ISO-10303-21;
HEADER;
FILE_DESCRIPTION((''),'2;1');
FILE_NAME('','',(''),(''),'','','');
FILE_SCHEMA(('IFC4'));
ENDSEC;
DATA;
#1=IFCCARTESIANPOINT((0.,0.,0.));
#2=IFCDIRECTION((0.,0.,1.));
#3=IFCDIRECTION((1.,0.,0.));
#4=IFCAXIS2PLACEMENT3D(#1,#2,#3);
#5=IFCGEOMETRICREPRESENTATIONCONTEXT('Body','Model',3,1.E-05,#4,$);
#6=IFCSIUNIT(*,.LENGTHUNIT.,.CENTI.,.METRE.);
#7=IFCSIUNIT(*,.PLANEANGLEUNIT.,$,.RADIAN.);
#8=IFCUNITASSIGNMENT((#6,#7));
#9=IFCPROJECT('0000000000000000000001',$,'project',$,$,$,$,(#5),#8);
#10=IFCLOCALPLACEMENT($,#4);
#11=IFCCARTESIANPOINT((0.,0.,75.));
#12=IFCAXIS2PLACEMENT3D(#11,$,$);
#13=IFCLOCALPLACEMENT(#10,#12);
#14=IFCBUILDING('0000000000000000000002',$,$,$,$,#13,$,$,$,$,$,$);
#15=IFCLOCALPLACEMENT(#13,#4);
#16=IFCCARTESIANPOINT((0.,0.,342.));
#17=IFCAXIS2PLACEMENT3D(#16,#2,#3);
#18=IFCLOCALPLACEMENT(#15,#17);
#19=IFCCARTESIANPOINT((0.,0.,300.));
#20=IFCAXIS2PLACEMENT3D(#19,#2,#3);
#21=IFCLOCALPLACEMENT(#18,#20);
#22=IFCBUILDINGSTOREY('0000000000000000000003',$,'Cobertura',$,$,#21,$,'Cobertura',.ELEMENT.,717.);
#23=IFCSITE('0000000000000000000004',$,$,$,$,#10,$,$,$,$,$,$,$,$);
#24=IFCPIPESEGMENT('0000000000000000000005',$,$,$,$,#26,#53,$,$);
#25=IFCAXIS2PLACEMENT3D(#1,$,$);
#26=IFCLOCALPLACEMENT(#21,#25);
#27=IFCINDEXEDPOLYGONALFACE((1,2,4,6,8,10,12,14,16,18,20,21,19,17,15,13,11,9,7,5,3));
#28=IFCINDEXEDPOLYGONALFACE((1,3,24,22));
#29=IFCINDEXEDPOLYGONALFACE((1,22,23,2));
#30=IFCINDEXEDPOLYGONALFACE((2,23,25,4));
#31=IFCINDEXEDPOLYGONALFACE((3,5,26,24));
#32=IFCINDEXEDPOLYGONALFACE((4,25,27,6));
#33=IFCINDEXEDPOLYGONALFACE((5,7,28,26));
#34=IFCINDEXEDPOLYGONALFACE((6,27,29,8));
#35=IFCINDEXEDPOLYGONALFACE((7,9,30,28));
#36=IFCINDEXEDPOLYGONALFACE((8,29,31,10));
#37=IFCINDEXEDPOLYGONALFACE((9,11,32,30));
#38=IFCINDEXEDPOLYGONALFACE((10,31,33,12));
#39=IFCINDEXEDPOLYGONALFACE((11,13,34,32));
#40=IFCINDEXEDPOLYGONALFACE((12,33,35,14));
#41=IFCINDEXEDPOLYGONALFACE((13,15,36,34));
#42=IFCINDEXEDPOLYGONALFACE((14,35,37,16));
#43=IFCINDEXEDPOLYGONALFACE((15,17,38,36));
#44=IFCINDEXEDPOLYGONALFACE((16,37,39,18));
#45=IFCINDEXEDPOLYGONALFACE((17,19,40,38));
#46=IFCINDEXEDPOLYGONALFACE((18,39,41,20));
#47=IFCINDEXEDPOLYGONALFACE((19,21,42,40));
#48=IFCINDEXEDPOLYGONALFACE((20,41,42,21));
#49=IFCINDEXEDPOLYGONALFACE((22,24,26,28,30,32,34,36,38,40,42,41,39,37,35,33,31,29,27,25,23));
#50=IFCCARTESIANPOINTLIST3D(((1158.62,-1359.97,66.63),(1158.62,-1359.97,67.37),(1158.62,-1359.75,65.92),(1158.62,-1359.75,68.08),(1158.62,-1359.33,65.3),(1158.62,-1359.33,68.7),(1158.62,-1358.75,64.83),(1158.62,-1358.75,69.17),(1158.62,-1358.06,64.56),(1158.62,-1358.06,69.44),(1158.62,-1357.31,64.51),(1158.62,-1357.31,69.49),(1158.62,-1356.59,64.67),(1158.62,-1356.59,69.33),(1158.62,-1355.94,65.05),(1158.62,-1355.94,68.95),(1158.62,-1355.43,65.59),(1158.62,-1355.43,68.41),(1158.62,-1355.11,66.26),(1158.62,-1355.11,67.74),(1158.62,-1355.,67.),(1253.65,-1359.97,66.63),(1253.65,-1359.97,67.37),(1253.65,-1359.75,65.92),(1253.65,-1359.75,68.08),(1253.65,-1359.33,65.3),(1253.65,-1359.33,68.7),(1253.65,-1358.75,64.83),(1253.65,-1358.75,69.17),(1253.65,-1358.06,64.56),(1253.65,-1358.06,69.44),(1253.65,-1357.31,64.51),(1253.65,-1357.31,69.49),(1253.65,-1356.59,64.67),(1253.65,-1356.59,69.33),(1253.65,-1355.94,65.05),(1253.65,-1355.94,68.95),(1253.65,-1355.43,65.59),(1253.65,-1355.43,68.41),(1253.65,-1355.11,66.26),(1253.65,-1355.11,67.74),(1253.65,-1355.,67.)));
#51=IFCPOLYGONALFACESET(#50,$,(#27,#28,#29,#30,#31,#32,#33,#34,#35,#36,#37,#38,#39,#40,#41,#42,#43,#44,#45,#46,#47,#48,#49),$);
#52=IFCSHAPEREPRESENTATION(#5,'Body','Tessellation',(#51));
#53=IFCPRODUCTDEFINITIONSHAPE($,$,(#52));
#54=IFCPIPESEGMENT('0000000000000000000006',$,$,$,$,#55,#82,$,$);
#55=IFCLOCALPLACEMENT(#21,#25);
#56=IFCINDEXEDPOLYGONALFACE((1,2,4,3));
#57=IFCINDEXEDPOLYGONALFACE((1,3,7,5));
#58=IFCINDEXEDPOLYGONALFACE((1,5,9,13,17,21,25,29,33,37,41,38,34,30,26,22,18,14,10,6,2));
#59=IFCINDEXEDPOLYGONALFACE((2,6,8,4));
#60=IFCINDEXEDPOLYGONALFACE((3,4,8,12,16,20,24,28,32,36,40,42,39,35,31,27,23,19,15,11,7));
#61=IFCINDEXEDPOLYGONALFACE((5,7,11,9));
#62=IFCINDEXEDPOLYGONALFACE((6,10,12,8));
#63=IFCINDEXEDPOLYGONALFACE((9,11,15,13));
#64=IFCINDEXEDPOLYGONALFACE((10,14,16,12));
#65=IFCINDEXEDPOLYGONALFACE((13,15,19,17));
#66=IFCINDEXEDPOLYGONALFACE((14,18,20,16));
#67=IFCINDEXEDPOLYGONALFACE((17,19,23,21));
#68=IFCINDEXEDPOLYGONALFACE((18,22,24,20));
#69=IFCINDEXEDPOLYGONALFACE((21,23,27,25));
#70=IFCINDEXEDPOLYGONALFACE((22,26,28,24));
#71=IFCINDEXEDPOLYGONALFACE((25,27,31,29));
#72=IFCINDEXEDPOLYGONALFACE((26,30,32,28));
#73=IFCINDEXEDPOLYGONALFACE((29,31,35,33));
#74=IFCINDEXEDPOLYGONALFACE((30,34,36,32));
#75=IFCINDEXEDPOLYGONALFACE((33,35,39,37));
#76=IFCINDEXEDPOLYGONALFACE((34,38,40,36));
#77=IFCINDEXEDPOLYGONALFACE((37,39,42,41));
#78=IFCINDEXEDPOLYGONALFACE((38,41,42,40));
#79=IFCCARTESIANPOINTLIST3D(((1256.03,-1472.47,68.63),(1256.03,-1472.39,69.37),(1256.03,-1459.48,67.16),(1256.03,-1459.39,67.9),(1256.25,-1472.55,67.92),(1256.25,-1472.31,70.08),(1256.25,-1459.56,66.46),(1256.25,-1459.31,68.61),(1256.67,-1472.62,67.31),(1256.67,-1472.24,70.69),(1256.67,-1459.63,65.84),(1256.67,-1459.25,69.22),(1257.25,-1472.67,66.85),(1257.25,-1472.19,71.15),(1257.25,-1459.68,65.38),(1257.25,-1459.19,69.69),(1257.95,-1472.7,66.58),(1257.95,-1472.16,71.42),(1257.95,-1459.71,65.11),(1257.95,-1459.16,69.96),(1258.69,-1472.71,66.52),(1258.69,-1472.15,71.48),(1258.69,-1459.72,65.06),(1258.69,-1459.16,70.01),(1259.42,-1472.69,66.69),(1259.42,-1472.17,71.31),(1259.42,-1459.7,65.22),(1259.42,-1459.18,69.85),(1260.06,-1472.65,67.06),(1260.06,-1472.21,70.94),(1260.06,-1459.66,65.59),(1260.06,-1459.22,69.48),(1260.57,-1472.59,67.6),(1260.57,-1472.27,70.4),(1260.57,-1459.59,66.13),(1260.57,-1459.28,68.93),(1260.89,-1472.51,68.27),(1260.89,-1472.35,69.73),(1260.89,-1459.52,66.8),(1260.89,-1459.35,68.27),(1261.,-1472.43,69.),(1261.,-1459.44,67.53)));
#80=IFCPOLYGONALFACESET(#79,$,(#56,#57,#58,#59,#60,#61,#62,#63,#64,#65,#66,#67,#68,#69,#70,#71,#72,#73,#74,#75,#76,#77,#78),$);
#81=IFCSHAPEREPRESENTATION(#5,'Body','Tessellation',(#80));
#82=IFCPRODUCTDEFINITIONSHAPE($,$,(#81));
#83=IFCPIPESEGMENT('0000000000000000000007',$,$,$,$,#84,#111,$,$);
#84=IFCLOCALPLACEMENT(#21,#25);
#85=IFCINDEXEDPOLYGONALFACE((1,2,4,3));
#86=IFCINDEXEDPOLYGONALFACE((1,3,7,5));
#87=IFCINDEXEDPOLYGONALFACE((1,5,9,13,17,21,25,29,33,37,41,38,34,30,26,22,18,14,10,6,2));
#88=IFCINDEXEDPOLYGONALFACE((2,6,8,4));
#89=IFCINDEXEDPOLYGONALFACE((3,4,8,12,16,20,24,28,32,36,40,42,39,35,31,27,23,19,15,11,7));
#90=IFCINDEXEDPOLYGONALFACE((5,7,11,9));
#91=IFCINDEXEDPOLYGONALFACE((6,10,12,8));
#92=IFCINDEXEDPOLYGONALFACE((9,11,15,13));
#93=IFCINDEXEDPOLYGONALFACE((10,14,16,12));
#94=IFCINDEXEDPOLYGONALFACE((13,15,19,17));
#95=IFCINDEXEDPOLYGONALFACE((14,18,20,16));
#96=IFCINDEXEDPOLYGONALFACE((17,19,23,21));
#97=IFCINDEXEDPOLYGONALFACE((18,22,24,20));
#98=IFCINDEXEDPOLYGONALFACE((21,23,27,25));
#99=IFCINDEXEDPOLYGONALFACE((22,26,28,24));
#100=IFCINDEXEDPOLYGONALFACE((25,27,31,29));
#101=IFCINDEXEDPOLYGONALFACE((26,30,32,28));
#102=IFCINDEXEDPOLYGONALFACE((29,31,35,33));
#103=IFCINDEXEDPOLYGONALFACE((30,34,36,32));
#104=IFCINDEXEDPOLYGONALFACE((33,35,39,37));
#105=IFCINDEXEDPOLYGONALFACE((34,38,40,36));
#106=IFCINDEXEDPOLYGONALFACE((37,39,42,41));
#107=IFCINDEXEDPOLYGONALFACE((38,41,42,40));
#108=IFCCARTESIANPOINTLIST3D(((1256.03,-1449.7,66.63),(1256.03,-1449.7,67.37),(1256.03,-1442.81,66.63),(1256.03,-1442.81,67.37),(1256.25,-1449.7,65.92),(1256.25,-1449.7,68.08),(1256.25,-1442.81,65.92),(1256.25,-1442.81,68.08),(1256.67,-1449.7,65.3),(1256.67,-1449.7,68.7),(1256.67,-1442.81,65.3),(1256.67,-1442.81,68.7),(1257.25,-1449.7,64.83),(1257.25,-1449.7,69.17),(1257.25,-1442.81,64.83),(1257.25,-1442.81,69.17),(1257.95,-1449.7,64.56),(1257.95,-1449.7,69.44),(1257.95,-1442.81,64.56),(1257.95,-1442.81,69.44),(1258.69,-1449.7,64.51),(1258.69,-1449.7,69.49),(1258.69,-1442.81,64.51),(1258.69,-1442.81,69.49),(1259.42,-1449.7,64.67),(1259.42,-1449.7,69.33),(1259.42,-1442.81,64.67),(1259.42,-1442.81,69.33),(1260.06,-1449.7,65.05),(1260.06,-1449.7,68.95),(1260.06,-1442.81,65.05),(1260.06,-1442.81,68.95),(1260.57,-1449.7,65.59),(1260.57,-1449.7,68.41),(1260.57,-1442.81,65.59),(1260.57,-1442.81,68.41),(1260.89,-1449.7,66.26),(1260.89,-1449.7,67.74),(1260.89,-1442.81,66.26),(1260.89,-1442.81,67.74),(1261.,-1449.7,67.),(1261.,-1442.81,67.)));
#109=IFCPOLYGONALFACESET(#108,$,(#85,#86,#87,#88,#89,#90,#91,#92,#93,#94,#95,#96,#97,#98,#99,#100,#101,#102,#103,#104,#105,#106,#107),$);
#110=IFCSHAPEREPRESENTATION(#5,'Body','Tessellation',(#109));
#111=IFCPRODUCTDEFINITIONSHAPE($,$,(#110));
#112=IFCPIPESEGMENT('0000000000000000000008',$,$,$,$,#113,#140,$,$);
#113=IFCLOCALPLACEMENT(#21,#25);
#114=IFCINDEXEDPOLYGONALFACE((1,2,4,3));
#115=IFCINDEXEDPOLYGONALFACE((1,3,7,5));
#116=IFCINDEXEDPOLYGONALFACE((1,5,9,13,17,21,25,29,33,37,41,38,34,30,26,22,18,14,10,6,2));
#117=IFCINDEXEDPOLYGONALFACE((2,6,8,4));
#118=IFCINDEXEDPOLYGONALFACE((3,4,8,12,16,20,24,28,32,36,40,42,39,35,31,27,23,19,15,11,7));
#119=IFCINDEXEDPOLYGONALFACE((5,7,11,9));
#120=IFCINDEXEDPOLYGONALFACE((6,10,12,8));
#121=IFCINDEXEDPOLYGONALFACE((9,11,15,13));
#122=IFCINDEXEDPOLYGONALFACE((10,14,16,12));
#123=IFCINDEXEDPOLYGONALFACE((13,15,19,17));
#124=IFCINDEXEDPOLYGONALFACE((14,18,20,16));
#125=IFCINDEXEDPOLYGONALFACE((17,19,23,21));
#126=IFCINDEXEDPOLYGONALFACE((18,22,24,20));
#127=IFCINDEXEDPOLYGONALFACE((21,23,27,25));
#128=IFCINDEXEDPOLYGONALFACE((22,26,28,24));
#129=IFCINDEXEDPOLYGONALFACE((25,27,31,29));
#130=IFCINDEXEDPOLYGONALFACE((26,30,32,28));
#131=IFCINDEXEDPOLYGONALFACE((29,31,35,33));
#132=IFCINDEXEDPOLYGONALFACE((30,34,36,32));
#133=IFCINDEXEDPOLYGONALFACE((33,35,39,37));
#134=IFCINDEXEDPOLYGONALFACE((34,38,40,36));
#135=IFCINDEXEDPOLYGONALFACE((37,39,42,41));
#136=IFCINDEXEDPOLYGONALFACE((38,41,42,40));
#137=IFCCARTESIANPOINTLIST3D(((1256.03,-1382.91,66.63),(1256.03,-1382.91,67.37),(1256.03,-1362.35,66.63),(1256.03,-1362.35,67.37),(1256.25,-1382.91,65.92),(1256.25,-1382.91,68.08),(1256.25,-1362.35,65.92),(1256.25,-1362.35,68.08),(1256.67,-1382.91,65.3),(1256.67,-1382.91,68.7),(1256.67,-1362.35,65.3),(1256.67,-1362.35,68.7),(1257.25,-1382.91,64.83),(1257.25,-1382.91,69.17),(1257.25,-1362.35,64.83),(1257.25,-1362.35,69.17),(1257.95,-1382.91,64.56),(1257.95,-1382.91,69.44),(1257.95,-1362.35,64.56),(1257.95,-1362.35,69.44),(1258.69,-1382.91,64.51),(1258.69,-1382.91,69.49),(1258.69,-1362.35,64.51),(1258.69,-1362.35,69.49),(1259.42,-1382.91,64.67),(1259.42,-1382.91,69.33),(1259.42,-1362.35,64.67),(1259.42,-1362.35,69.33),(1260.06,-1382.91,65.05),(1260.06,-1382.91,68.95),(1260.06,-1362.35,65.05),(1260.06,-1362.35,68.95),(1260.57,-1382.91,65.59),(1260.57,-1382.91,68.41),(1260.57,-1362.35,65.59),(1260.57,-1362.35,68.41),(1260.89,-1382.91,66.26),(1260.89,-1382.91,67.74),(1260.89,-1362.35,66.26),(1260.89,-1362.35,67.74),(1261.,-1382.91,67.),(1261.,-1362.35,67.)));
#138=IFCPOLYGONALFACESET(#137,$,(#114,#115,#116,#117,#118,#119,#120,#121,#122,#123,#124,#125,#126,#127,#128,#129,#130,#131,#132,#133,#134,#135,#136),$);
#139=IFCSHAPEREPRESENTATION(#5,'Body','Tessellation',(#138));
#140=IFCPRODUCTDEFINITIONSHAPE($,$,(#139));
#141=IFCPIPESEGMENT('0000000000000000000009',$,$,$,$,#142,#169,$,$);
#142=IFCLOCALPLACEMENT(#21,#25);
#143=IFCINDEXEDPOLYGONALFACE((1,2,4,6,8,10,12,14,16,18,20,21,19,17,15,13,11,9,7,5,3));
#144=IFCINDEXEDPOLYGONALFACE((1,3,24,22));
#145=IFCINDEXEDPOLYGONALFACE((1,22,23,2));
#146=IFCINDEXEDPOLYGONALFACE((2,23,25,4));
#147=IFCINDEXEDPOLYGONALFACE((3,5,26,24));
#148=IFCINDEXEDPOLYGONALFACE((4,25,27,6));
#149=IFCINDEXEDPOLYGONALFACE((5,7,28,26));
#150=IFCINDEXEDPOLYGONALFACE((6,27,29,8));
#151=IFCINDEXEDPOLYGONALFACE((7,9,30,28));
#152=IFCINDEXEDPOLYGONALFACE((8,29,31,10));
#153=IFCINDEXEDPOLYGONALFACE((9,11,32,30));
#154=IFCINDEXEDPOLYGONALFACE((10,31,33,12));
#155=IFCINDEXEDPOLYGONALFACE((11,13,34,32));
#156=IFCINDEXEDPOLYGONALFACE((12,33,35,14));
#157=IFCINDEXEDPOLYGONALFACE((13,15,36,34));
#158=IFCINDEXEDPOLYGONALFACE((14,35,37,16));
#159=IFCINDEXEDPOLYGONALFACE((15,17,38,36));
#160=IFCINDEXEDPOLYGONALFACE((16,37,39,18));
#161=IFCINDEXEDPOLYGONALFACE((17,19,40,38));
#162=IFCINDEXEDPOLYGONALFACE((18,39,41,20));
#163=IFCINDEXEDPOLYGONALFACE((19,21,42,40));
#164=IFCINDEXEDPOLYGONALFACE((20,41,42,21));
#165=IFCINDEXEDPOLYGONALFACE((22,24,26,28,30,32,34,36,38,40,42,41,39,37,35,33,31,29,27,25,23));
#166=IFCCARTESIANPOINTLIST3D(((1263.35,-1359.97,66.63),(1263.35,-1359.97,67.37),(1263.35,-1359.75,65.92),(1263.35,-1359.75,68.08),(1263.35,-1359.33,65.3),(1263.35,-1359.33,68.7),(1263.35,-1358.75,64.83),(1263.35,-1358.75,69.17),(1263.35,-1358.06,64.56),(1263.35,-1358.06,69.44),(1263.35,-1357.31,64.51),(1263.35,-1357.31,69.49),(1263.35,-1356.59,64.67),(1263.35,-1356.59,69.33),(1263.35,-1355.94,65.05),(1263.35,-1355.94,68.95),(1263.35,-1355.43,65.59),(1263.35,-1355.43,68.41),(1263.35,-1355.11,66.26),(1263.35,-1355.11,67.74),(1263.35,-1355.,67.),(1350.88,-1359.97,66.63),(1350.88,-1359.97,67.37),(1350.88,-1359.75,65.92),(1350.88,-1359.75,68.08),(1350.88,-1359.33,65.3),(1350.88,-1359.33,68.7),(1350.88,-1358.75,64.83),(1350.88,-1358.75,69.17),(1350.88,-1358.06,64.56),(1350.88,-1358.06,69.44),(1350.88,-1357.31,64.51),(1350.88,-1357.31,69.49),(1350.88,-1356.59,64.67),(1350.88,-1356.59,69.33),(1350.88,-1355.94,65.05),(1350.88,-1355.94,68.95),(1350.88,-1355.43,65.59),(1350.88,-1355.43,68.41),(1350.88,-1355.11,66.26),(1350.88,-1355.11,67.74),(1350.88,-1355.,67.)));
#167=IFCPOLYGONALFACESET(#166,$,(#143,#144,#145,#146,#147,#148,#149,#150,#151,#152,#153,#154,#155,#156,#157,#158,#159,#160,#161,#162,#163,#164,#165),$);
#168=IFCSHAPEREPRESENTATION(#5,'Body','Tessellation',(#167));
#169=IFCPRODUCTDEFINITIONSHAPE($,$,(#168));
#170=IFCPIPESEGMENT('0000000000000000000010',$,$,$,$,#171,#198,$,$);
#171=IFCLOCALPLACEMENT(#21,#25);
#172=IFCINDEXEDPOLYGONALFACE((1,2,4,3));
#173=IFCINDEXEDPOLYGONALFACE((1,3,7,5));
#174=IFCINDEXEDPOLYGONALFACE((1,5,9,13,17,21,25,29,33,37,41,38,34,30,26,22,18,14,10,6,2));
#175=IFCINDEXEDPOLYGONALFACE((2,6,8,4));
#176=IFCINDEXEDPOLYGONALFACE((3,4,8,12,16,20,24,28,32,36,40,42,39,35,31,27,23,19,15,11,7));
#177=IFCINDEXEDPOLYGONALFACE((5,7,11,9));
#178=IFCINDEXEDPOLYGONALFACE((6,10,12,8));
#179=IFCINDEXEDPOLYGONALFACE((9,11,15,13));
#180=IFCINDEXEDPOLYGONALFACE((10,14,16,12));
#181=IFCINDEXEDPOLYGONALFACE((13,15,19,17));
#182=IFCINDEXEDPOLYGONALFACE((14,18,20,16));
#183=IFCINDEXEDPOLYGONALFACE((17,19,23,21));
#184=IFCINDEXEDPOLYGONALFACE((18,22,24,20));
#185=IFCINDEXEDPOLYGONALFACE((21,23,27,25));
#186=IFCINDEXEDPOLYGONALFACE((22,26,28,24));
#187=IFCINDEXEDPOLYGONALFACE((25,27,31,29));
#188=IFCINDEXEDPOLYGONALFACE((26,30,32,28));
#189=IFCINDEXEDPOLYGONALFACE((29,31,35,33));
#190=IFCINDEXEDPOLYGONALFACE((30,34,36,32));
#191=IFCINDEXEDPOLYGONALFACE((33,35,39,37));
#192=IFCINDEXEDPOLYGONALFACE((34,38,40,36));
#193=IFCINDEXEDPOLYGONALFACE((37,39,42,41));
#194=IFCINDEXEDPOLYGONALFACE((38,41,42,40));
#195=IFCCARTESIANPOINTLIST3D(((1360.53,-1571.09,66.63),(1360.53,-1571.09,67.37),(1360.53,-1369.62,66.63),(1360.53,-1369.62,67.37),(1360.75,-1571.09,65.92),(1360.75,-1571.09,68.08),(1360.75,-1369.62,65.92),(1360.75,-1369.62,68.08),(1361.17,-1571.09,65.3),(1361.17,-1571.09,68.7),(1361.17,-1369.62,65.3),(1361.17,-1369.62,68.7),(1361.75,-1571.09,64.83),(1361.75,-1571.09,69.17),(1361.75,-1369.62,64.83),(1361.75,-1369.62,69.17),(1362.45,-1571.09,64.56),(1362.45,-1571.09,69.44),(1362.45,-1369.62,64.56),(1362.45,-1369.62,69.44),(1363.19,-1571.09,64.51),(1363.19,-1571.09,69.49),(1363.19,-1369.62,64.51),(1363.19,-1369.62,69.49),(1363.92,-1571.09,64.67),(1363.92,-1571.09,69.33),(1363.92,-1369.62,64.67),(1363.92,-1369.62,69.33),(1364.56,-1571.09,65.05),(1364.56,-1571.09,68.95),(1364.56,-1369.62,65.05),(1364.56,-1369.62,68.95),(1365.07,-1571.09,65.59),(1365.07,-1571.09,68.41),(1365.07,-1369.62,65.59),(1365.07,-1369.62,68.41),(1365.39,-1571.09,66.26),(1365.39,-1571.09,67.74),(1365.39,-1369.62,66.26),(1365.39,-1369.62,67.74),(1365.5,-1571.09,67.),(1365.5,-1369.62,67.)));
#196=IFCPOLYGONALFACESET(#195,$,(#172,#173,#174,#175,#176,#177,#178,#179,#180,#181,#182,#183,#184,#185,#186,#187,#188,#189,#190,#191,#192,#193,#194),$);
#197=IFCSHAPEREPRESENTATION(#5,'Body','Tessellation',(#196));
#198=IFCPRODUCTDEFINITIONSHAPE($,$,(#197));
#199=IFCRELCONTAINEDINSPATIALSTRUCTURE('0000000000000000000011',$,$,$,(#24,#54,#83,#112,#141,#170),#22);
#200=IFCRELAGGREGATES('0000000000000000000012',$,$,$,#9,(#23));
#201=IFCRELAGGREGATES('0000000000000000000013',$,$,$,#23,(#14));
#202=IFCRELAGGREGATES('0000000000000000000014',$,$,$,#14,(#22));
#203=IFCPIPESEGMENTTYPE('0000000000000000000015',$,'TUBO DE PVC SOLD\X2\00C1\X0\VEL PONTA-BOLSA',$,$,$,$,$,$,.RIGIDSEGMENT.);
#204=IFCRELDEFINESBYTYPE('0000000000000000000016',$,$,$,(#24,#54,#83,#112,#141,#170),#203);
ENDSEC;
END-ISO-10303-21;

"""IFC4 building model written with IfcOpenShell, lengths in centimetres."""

from ifc_helpers import new_model, si_unit, frame, origin_with_axes, origin_2d_with_axis, place, context, project, spatial, circle, extrude, type_object, element, save


model = new_model("IFC4")

# Units and contexts
model_context = context("Model", 3, precision=1e-05, world=origin_with_axes(), identifier="Body")
ifc_project = project(units=[si_unit("LENGTHUNIT", "METRE", prefix="CENTI"), si_unit("PLANEANGLEUNIT", "RADIAN")], contexts=[model_context])

# Site, building, storey
site_placement = place(None, origin_with_axes())
site = spatial("IfcSite", under=ifc_project, at=site_placement)
building_placement = place(site_placement, frame((0.0, 0.0, 75.0)))
building = spatial("IfcBuilding", under=site, at=building_placement)
placement_1 = place(building_placement, origin_with_axes())
placement_2 = place(placement_1, frame((0.0, 0.0, 342.0), z_axis=(0.0, 0.0, 1.0), x_axis=(1.0, 0.0, 0.0)))
storey_placement = place(placement_2, frame((0.0, 0.0, 300.0), z_axis=(0.0, 0.0, 1.0), x_axis=(1.0, 0.0, 0.0)))
storey = spatial("IfcBuildingStorey", under=building, at=storey_placement, Name="Cobertura", LongName="Cobertura", CompositionType="ELEMENT", Elevation=717.0)

# Pipe segments
pipe_segment_type_1 = type_object("IfcPipeSegmentType", Name="TUBO DE PVC SOLDÁVEL PONTA-BOLSA", PredefinedType="RIGIDSEGMENT")
pipe_segment_1_placement = place(storey_placement, frame((1206.14, -1357.5, 69.5), z_axis=(0.0, 0.0, 1.0), x_axis=(1.0, 0.0, 0.0)))
element("IfcPipeSegment", 1, at=pipe_segment_1_placement, inside=storey, type_object=pipe_segment_type_1, context=model_context, shape_type="SolidModel", body=[
    extrude(circle(Radius=2.5, at=origin_2d_with_axis()), frame((47.52, 0.0, -2.5), z_axis=(-1.0, 0.0, 0.0), x_axis=(0.0, 1.0, 0.0)), (0.0, 0.0, 1.0), 95.03),
])
pipe_segment_2_placement = place(storey_placement, frame((1258.5, -1465.93, 71.48), z_axis=(0.0, 0.0, 1.0), x_axis=(1.0, 0.0, 0.0)))
element("IfcPipeSegment", 2, at=pipe_segment_2_placement, inside=storey, type_object=pipe_segment_type_1, context=model_context, shape_type="SolidModel", body=[
    extrude(circle(Radius=2.5, at=origin_2d_with_axis()), frame((0.0, -6.5, -2.48), z_axis=(0.0, 0.993693, -0.112136), x_axis=(1.0, 0.0, 0.0)), (0.0, 0.0, 1.0), 13.08),
])
pipe_segment_3_placement = place(storey_placement, frame((1258.5, -1446.26, 69.5), z_axis=(0.0, 0.0, 1.0), x_axis=(1.0, 0.0, 0.0)))
element("IfcPipeSegment", 3, at=pipe_segment_3_placement, inside=storey, type_object=pipe_segment_type_1, context=model_context, shape_type="SolidModel", body=[
    extrude(circle(Radius=2.5, at=origin_2d_with_axis()), frame((0.0, -3.45, -2.5), z_axis=(0.0, 1.0, 0.0), x_axis=(1.0, 0.0, 0.0)), (0.0, 0.0, 1.0), 6.9),
])
pipe_segment_4_placement = place(storey_placement, frame((1258.5, -1372.63, 69.5), z_axis=(0.0, 0.0, 1.0), x_axis=(1.0, 0.0, 0.0)))
element("IfcPipeSegment", 4, at=pipe_segment_4_placement, inside=storey, type_object=pipe_segment_type_1, context=model_context, shape_type="SolidModel", body=[
    extrude(circle(Radius=2.5, at=origin_2d_with_axis()), frame((0.0, -10.28, -2.5), z_axis=(0.0, 1.0, 0.0), x_axis=(1.0, 0.0, 0.0)), (0.0, 0.0, 1.0), 20.56),
])
pipe_segment_5_placement = place(storey_placement, frame((1307.12, -1357.5, 69.5), z_axis=(0.0, 0.0, 1.0), x_axis=(1.0, 0.0, 0.0)))
element("IfcPipeSegment", 5, at=pipe_segment_5_placement, inside=storey, type_object=pipe_segment_type_1, context=model_context, shape_type="SolidModel", body=[
    extrude(circle(Radius=2.5, at=origin_2d_with_axis()), frame((-43.76, 0.0, -2.5), z_axis=(1.0, 0.0, 0.0), x_axis=(0.0, 1.0, 0.0)), (0.0, 0.0, 1.0), 87.53),
])
pipe_segment_6_placement = place(storey_placement, frame((1363.0, -1470.35, 69.5), z_axis=(0.0, 0.0, 1.0), x_axis=(1.0, 0.0, 0.0)))
element("IfcPipeSegment", 6, at=pipe_segment_6_placement, inside=storey, type_object=pipe_segment_type_1, context=model_context, shape_type="SolidModel", body=[
    extrude(circle(Radius=2.5, at=origin_2d_with_axis()), frame((0.0, 100.73, -2.5), z_axis=(0.0, -1.0, 0.0), x_axis=(1.0, 0.0, 0.0)), (0.0, 0.0, 1.0), 201.47),
])

save(model, "model.ifc")
